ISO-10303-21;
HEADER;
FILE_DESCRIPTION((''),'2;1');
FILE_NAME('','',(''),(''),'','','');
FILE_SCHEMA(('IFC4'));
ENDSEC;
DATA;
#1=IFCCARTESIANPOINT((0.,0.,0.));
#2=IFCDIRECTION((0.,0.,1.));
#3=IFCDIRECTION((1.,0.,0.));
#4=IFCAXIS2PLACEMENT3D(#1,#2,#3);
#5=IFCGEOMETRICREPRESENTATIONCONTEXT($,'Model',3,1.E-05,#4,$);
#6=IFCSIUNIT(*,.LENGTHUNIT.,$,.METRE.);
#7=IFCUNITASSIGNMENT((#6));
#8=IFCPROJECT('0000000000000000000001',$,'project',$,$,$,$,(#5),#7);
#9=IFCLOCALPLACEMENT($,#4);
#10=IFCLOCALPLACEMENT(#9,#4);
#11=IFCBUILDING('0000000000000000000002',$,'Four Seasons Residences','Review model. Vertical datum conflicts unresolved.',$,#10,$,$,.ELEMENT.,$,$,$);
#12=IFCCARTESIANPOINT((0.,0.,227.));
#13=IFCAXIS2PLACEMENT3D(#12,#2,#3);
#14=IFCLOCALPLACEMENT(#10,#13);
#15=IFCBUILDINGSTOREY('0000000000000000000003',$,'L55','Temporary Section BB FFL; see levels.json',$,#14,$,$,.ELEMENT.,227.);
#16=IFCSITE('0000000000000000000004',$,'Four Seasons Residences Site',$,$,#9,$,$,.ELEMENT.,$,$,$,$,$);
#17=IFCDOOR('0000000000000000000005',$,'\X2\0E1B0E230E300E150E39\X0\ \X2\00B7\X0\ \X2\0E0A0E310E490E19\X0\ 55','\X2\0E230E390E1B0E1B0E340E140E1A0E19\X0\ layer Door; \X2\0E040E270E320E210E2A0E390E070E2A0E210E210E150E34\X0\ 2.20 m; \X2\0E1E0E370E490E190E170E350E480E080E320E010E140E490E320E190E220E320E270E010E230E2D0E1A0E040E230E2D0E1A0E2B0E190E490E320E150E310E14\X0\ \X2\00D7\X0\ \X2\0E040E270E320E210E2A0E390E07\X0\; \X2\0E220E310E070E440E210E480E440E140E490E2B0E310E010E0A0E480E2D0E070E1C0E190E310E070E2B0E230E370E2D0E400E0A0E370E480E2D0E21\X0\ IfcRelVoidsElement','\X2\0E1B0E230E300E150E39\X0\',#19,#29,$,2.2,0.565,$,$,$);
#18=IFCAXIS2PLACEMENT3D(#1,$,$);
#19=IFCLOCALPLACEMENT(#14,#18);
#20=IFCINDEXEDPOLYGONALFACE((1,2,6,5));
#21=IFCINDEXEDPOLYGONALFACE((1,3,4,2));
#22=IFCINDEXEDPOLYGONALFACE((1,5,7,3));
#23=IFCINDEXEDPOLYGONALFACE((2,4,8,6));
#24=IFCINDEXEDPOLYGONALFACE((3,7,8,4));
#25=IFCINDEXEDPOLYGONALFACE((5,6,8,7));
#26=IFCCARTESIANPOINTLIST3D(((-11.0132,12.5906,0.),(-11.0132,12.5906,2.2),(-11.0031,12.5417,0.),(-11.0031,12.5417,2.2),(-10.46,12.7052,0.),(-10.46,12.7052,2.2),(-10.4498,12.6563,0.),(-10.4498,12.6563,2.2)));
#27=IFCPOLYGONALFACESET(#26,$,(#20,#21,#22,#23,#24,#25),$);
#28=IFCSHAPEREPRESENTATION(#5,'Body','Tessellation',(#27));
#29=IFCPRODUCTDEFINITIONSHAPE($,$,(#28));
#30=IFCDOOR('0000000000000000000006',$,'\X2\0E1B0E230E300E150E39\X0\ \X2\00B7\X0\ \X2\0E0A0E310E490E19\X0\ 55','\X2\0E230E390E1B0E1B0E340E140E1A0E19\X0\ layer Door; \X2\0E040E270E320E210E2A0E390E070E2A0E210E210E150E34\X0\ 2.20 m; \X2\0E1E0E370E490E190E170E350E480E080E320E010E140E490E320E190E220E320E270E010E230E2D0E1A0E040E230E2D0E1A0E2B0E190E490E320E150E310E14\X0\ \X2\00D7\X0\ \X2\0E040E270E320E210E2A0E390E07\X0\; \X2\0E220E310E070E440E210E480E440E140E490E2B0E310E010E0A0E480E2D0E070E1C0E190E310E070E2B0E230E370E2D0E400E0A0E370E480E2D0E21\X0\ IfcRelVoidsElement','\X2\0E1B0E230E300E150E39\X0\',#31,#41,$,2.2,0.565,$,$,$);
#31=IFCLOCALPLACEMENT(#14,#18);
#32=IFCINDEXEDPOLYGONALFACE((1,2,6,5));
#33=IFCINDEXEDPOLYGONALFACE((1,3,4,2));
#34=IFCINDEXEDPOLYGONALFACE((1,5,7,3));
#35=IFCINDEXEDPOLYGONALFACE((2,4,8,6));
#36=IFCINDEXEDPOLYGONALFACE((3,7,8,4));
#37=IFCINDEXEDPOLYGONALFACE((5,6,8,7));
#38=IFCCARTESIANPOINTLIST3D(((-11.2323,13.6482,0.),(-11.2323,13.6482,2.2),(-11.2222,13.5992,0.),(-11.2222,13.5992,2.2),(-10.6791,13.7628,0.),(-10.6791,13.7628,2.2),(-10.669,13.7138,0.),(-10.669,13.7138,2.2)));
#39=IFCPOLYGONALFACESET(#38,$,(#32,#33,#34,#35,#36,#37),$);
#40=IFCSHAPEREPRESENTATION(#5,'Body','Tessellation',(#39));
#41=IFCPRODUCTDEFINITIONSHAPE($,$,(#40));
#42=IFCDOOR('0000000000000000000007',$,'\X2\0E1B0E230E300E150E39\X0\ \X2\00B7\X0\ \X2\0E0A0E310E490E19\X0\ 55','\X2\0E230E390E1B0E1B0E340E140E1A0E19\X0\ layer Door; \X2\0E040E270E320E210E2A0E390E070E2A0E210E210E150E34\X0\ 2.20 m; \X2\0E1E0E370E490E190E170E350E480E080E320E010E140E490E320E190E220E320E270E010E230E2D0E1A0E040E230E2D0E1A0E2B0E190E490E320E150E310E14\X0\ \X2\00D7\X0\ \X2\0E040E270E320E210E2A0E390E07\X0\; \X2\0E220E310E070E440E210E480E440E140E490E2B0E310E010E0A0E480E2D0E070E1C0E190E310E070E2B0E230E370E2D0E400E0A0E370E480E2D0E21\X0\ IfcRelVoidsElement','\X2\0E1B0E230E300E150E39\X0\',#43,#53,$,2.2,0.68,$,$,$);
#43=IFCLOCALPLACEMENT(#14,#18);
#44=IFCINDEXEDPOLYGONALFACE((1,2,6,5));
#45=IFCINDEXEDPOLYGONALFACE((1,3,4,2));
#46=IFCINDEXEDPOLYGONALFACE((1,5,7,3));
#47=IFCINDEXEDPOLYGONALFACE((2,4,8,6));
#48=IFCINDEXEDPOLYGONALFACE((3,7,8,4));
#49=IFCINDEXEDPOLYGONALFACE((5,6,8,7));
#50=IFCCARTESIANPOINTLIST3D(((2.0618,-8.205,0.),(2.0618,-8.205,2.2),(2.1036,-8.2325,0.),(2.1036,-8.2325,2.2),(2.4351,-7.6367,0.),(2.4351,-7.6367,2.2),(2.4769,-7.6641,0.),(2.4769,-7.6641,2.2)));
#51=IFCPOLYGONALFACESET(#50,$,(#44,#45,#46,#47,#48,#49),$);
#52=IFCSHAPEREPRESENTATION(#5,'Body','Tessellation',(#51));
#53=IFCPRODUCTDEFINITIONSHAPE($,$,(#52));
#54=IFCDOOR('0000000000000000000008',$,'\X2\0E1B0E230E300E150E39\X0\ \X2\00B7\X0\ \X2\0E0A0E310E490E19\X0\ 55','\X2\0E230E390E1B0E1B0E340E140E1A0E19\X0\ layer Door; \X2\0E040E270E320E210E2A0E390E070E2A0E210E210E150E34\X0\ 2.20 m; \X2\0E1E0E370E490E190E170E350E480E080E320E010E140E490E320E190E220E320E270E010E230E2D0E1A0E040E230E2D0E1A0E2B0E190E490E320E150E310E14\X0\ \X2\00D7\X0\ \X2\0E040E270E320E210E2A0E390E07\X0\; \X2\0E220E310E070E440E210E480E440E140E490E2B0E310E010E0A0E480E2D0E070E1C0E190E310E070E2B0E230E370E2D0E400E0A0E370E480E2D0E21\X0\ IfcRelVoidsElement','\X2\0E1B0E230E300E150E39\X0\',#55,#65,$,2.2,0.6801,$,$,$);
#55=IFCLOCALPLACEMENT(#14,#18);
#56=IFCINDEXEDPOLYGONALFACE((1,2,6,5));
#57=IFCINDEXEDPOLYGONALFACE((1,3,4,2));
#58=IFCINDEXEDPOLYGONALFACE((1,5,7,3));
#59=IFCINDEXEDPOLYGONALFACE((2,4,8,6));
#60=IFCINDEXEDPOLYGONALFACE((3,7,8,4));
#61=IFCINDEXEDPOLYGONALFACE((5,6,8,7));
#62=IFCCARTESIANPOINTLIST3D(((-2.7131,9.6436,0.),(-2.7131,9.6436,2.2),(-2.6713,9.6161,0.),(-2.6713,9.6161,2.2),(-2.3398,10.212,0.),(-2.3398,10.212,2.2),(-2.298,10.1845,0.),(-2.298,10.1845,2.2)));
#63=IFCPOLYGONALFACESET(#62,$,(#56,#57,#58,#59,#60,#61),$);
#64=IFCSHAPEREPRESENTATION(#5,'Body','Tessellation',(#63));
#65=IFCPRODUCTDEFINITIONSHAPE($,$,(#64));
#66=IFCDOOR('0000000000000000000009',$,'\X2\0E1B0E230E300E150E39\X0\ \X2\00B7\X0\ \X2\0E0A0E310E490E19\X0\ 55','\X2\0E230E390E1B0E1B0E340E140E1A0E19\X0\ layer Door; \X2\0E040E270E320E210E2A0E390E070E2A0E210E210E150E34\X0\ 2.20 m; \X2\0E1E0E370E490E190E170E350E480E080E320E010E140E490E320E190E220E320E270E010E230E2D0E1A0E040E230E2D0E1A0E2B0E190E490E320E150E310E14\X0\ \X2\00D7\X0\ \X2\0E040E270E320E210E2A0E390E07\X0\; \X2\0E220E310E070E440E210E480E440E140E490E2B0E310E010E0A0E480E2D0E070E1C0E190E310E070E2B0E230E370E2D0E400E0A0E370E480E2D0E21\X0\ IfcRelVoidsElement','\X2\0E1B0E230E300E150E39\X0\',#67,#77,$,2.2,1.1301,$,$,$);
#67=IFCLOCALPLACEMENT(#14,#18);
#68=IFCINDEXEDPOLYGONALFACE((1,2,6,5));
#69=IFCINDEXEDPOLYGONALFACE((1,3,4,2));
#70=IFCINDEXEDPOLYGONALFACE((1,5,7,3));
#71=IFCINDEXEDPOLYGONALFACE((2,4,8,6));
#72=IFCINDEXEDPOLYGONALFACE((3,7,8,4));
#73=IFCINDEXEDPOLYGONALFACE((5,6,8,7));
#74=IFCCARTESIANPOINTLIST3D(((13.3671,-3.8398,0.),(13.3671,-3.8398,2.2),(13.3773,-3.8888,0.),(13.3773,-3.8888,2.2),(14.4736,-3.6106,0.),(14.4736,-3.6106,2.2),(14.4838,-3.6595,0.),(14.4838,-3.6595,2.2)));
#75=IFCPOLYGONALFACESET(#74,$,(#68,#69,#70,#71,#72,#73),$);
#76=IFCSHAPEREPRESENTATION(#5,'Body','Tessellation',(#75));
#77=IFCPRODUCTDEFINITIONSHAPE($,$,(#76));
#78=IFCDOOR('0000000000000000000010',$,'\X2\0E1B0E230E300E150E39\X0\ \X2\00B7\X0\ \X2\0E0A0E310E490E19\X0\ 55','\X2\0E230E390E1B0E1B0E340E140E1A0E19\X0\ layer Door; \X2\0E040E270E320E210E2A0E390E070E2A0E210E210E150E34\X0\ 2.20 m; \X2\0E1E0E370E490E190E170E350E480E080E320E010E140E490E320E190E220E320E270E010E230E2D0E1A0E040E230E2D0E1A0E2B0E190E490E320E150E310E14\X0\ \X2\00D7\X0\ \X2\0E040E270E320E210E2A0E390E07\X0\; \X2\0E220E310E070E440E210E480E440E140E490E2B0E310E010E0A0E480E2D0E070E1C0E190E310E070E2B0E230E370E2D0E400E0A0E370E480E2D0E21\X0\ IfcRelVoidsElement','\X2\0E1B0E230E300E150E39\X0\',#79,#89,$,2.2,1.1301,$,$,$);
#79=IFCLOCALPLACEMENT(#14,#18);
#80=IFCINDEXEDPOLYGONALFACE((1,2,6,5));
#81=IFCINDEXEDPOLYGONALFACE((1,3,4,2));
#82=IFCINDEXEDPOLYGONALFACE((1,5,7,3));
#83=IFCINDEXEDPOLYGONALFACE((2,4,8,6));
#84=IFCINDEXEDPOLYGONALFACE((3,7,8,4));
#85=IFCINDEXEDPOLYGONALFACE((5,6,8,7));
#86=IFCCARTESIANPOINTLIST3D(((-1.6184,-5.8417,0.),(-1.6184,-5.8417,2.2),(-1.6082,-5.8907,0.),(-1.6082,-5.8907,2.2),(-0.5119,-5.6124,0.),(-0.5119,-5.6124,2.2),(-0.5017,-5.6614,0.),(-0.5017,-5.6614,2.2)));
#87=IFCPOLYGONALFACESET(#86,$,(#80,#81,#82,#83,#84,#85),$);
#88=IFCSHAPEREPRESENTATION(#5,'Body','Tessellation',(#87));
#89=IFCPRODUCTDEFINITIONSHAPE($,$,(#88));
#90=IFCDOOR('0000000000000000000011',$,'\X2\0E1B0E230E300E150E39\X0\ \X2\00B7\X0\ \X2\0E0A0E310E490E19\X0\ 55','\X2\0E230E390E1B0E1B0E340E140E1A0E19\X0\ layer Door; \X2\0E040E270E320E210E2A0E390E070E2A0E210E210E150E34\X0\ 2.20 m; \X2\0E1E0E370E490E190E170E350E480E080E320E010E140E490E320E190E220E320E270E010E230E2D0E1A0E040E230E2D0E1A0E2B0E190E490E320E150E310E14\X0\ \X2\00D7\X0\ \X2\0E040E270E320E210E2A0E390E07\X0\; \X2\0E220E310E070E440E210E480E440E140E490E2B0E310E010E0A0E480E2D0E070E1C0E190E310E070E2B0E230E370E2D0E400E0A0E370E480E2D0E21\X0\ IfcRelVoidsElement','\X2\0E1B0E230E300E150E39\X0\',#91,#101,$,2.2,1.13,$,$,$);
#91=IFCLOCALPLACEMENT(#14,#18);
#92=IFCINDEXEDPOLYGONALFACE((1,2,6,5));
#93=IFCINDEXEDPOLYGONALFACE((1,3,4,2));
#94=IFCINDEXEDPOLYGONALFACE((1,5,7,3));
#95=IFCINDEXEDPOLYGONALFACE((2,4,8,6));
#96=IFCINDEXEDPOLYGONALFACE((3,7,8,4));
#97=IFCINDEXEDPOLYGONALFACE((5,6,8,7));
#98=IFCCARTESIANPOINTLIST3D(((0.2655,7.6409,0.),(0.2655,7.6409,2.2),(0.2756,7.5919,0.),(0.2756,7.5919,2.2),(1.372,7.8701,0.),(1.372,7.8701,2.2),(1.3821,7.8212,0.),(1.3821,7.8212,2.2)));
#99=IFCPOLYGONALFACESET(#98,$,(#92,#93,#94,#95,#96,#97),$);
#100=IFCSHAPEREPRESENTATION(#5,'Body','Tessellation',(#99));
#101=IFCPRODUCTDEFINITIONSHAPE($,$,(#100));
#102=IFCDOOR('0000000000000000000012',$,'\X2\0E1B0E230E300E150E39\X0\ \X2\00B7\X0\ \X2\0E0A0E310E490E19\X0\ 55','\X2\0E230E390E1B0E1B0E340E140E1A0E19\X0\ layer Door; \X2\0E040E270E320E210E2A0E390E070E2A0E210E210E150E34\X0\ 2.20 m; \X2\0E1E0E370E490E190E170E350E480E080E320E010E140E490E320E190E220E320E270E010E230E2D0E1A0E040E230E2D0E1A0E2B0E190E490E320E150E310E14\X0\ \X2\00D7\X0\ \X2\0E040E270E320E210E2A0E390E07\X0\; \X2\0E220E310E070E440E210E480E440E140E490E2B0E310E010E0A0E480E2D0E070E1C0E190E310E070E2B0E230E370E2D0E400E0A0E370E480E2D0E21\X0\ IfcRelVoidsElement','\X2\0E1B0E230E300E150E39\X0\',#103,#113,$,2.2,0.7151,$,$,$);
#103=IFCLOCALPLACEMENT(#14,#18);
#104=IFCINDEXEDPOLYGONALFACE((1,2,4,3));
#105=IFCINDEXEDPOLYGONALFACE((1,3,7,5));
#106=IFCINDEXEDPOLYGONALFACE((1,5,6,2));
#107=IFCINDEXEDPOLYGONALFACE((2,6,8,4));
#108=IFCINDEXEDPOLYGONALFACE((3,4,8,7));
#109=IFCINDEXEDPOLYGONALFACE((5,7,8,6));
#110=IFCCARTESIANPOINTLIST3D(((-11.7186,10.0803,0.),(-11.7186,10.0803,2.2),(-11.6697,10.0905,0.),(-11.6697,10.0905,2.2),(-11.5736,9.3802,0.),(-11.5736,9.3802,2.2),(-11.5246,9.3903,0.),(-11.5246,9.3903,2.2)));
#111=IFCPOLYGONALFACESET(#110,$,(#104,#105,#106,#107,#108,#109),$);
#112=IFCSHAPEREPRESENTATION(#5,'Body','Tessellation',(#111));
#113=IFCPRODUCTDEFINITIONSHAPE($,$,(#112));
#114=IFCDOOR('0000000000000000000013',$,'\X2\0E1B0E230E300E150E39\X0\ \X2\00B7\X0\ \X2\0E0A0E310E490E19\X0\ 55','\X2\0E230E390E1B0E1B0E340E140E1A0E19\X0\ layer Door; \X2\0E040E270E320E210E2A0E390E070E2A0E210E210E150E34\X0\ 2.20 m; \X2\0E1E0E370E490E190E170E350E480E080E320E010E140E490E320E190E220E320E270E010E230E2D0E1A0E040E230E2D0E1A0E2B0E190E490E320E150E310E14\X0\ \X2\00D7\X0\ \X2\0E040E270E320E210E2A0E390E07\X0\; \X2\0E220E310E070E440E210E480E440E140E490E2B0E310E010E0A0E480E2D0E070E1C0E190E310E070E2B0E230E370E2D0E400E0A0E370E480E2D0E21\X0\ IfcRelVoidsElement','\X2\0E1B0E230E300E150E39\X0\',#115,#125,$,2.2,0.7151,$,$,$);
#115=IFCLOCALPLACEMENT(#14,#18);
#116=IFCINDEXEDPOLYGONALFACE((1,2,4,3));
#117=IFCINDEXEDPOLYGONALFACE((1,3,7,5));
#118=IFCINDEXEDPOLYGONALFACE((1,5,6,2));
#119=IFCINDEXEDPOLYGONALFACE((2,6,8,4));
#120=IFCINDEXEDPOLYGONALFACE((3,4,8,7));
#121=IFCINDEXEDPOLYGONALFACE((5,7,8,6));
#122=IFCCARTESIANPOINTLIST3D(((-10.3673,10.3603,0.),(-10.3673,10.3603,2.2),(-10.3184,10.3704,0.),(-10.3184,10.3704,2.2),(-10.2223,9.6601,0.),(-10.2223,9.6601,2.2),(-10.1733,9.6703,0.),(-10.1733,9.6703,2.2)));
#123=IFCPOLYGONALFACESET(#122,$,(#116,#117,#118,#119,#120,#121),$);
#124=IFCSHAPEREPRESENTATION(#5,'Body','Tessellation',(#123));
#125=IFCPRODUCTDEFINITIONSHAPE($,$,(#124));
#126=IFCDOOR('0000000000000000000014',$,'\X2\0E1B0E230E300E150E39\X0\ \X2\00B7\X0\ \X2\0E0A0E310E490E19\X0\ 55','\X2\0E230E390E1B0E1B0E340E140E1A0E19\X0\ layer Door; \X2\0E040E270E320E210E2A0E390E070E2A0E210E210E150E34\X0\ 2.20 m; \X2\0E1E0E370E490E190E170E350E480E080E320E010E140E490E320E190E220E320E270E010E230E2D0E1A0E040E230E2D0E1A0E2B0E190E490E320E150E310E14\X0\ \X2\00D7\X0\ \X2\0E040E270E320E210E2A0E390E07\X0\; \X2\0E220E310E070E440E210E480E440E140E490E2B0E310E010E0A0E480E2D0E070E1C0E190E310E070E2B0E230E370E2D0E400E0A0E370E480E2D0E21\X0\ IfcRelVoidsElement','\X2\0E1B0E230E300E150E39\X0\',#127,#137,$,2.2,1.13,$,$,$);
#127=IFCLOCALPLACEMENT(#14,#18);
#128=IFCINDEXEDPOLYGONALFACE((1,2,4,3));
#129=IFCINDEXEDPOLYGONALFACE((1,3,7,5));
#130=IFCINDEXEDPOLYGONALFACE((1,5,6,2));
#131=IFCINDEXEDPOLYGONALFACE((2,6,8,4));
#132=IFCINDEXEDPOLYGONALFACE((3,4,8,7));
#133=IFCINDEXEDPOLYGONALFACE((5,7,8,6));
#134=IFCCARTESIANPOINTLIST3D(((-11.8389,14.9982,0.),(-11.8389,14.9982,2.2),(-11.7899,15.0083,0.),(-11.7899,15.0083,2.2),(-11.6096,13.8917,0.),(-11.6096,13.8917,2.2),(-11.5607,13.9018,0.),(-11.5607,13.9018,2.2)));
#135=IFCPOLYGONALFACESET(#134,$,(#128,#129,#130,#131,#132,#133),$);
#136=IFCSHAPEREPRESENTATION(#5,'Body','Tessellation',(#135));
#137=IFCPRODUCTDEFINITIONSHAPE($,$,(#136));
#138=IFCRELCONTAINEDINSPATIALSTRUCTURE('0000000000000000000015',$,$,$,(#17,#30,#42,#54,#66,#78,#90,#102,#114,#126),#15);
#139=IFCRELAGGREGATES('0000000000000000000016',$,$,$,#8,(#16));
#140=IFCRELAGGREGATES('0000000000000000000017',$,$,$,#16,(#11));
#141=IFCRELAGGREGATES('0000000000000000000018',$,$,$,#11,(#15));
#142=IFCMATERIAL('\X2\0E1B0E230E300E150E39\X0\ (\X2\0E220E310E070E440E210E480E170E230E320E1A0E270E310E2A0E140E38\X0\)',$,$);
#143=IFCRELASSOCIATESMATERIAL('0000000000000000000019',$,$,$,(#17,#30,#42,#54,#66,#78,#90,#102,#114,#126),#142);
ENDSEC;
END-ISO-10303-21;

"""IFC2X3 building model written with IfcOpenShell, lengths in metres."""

from ifc_helpers import new_model, si_unit, frame, origin_with_axes, place, context, project, spatial, polyline, outline, extrude, material, element, save


model = new_model("IFC2X3")

# Units and contexts
model_context = context("Model", 3, precision=1e-05, world=origin_with_axes())
ifc_project = project(units=[si_unit("LENGTHUNIT", "METRE")], contexts=[model_context])

# Site, building, storey
site_placement = place(None, origin_with_axes())
site = spatial("IfcSite", under=ifc_project, at=site_placement, Name="Four Seasons Residences Site", CompositionType="ELEMENT")
building_placement = place(site_placement, origin_with_axes())
building = spatial("IfcBuilding", under=site, at=building_placement, Name="Four Seasons Residences", Description="Review model. Vertical datum conflicts unresolved.", CompositionType="ELEMENT")
storey_placement = place(building_placement, frame((0.0, 0.0, 227.0), z_axis=(0.0, 0.0, 1.0), x_axis=(1.0, 0.0, 0.0)))
storey = spatial("IfcBuildingStorey", under=building, at=storey_placement, Name="L55", Description="Temporary Section BB FFL; see levels.json", CompositionType="ELEMENT", Elevation=227.0)

# Doors
ifc_material_1 = material(Name="ประตู (ยังไม่ทราบวัสดุ)")
door_1_placement = place(storey_placement, origin_with_axes())
element("IfcDoor", 1, at=door_1_placement, inside=storey, material=ifc_material_1, Name="ประตู · ชั้น 55", Description="รูปปิดบน layer Door; ความสูงสมมติ 2.20 m; พื้นที่จากด้านยาวกรอบครอบหน้าตัด × ความสูง; ยังไม่ได้หักช่องผนังหรือเชื่อม IfcRelVoidsElement", ObjectType="ประตู", OverallHeight=2.2, OverallWidth=0.565, context=model_context, shape_type="SweptSolid", body=[
    extrude(outline(polyline([(-11.0031, 12.5417), (-10.4498, 12.6563), (-10.46, 12.7052), (-11.0132, 12.5906), (-11.0031, 12.5417)])), origin_with_axes(), (0.0, 0.0, 1.0), 2.2),
])
door_2_placement = place(storey_placement, origin_with_axes())
element("IfcDoor", 2, at=door_2_placement, inside=storey, material=ifc_material_1, Name="ประตู · ชั้น 55", Description="รูปปิดบน layer Door; ความสูงสมมติ 2.20 m; พื้นที่จากด้านยาวกรอบครอบหน้าตัด × ความสูง; ยังไม่ได้หักช่องผนังหรือเชื่อม IfcRelVoidsElement", ObjectType="ประตู", OverallHeight=2.2, OverallWidth=0.565, context=model_context, shape_type="SweptSolid", body=[
    extrude(outline(polyline([(-11.2323, 13.6482), (-10.6791, 13.7628), (-10.669, 13.7138), (-11.2222, 13.5992), (-11.2323, 13.6482)])), origin_with_axes(), (0.0, 0.0, 1.0), 2.2),
])
door_3_placement = place(storey_placement, origin_with_axes())
element("IfcDoor", 3, at=door_3_placement, inside=storey, material=ifc_material_1, Name="ประตู · ชั้น 55", Description="รูปปิดบน layer Door; ความสูงสมมติ 2.20 m; พื้นที่จากด้านยาวกรอบครอบหน้าตัด × ความสูง; ยังไม่ได้หักช่องผนังหรือเชื่อม IfcRelVoidsElement", ObjectType="ประตู", OverallHeight=2.2, OverallWidth=0.68, context=model_context, shape_type="SweptSolid", body=[
    extrude(outline(polyline([(2.0618, -8.205), (2.4351, -7.6367), (2.4769, -7.6641), (2.1036, -8.2325), (2.0618, -8.205)])), origin_with_axes(), (0.0, 0.0, 1.0), 2.2),
])
door_4_placement = place(storey_placement, origin_with_axes())
element("IfcDoor", 4, at=door_4_placement, inside=storey, material=ifc_material_1, Name="ประตู · ชั้น 55", Description="รูปปิดบน layer Door; ความสูงสมมติ 2.20 m; พื้นที่จากด้านยาวกรอบครอบหน้าตัด × ความสูง; ยังไม่ได้หักช่องผนังหรือเชื่อม IfcRelVoidsElement", ObjectType="ประตู", OverallHeight=2.2, OverallWidth=0.6801, context=model_context, shape_type="SweptSolid", body=[
    extrude(outline(polyline([(-2.298, 10.1845), (-2.6713, 9.6161), (-2.7131, 9.6436), (-2.3398, 10.212), (-2.298, 10.1845)])), origin_with_axes(), (0.0, 0.0, 1.0), 2.2),
])
door_5_placement = place(storey_placement, origin_with_axes())
element("IfcDoor", 5, at=door_5_placement, inside=storey, material=ifc_material_1, Name="ประตู · ชั้น 55", Description="รูปปิดบน layer Door; ความสูงสมมติ 2.20 m; พื้นที่จากด้านยาวกรอบครอบหน้าตัด × ความสูง; ยังไม่ได้หักช่องผนังหรือเชื่อม IfcRelVoidsElement", ObjectType="ประตู", OverallHeight=2.2, OverallWidth=1.1301, context=model_context, shape_type="SweptSolid", body=[
    extrude(outline(polyline([(14.4838, -3.6595), (13.3773, -3.8888), (13.3671, -3.8398), (14.4736, -3.6106), (14.4838, -3.6595)])), origin_with_axes(), (0.0, 0.0, 1.0), 2.2),
])
door_6_placement = place(storey_placement, origin_with_axes())
element("IfcDoor", 6, at=door_6_placement, inside=storey, material=ifc_material_1, Name="ประตู · ชั้น 55", Description="รูปปิดบน layer Door; ความสูงสมมติ 2.20 m; พื้นที่จากด้านยาวกรอบครอบหน้าตัด × ความสูง; ยังไม่ได้หักช่องผนังหรือเชื่อม IfcRelVoidsElement", ObjectType="ประตู", OverallHeight=2.2, OverallWidth=1.1301, context=model_context, shape_type="SweptSolid", body=[
    extrude(outline(polyline([(-1.6184, -5.8417), (-0.5119, -5.6124), (-0.5017, -5.6614), (-1.6082, -5.8907), (-1.6184, -5.8417)])), origin_with_axes(), (0.0, 0.0, 1.0), 2.2),
])
door_7_placement = place(storey_placement, origin_with_axes())
element("IfcDoor", 7, at=door_7_placement, inside=storey, material=ifc_material_1, Name="ประตู · ชั้น 55", Description="รูปปิดบน layer Door; ความสูงสมมติ 2.20 m; พื้นที่จากด้านยาวกรอบครอบหน้าตัด × ความสูง; ยังไม่ได้หักช่องผนังหรือเชื่อม IfcRelVoidsElement", ObjectType="ประตู", OverallHeight=2.2, OverallWidth=1.13, context=model_context, shape_type="SweptSolid", body=[
    extrude(outline(polyline([(1.3821, 7.8212), (0.2756, 7.5919), (0.2655, 7.6409), (1.372, 7.8701), (1.3821, 7.8212)])), origin_with_axes(), (0.0, 0.0, 1.0), 2.2),
])
door_8_placement = place(storey_placement, origin_with_axes())
element("IfcDoor", 8, at=door_8_placement, inside=storey, material=ifc_material_1, Name="ประตู · ชั้น 55", Description="รูปปิดบน layer Door; ความสูงสมมติ 2.20 m; พื้นที่จากด้านยาวกรอบครอบหน้าตัด × ความสูง; ยังไม่ได้หักช่องผนังหรือเชื่อม IfcRelVoidsElement", ObjectType="ประตู", OverallHeight=2.2, OverallWidth=0.7151, context=model_context, shape_type="SweptSolid", body=[
    extrude(outline(polyline([(-11.7186, 10.0803), (-11.5736, 9.3802), (-11.5246, 9.3903), (-11.6697, 10.0905), (-11.7186, 10.0803)])), origin_with_axes(), (0.0, 0.0, 1.0), 2.2),
])
door_9_placement = place(storey_placement, origin_with_axes())
element("IfcDoor", 9, at=door_9_placement, inside=storey, material=ifc_material_1, Name="ประตู · ชั้น 55", Description="รูปปิดบน layer Door; ความสูงสมมติ 2.20 m; พื้นที่จากด้านยาวกรอบครอบหน้าตัด × ความสูง; ยังไม่ได้หักช่องผนังหรือเชื่อม IfcRelVoidsElement", ObjectType="ประตู", OverallHeight=2.2, OverallWidth=0.7151, context=model_context, shape_type="SweptSolid", body=[
    extrude(outline(polyline([(-10.3184, 10.3704), (-10.1733, 9.6703), (-10.2223, 9.6601), (-10.3673, 10.3603), (-10.3184, 10.3704)])), origin_with_axes(), (0.0, 0.0, 1.0), 2.2),
])
door_10_placement = place(storey_placement, origin_with_axes())
element("IfcDoor", 10, at=door_10_placement, inside=storey, material=ifc_material_1, Name="ประตู · ชั้น 55", Description="รูปปิดบน layer Door; ความสูงสมมติ 2.20 m; พื้นที่จากด้านยาวกรอบครอบหน้าตัด × ความสูง; ยังไม่ได้หักช่องผนังหรือเชื่อม IfcRelVoidsElement", ObjectType="ประตู", OverallHeight=2.2, OverallWidth=1.13, context=model_context, shape_type="SweptSolid", body=[
    extrude(outline(polyline([(-11.7899, 15.0083), (-11.5607, 13.9018), (-11.6096, 13.8917), (-11.8389, 14.9982), (-11.7899, 15.0083)])), origin_with_axes(), (0.0, 0.0, 1.0), 2.2),
])

save(model, "model.ifc")
